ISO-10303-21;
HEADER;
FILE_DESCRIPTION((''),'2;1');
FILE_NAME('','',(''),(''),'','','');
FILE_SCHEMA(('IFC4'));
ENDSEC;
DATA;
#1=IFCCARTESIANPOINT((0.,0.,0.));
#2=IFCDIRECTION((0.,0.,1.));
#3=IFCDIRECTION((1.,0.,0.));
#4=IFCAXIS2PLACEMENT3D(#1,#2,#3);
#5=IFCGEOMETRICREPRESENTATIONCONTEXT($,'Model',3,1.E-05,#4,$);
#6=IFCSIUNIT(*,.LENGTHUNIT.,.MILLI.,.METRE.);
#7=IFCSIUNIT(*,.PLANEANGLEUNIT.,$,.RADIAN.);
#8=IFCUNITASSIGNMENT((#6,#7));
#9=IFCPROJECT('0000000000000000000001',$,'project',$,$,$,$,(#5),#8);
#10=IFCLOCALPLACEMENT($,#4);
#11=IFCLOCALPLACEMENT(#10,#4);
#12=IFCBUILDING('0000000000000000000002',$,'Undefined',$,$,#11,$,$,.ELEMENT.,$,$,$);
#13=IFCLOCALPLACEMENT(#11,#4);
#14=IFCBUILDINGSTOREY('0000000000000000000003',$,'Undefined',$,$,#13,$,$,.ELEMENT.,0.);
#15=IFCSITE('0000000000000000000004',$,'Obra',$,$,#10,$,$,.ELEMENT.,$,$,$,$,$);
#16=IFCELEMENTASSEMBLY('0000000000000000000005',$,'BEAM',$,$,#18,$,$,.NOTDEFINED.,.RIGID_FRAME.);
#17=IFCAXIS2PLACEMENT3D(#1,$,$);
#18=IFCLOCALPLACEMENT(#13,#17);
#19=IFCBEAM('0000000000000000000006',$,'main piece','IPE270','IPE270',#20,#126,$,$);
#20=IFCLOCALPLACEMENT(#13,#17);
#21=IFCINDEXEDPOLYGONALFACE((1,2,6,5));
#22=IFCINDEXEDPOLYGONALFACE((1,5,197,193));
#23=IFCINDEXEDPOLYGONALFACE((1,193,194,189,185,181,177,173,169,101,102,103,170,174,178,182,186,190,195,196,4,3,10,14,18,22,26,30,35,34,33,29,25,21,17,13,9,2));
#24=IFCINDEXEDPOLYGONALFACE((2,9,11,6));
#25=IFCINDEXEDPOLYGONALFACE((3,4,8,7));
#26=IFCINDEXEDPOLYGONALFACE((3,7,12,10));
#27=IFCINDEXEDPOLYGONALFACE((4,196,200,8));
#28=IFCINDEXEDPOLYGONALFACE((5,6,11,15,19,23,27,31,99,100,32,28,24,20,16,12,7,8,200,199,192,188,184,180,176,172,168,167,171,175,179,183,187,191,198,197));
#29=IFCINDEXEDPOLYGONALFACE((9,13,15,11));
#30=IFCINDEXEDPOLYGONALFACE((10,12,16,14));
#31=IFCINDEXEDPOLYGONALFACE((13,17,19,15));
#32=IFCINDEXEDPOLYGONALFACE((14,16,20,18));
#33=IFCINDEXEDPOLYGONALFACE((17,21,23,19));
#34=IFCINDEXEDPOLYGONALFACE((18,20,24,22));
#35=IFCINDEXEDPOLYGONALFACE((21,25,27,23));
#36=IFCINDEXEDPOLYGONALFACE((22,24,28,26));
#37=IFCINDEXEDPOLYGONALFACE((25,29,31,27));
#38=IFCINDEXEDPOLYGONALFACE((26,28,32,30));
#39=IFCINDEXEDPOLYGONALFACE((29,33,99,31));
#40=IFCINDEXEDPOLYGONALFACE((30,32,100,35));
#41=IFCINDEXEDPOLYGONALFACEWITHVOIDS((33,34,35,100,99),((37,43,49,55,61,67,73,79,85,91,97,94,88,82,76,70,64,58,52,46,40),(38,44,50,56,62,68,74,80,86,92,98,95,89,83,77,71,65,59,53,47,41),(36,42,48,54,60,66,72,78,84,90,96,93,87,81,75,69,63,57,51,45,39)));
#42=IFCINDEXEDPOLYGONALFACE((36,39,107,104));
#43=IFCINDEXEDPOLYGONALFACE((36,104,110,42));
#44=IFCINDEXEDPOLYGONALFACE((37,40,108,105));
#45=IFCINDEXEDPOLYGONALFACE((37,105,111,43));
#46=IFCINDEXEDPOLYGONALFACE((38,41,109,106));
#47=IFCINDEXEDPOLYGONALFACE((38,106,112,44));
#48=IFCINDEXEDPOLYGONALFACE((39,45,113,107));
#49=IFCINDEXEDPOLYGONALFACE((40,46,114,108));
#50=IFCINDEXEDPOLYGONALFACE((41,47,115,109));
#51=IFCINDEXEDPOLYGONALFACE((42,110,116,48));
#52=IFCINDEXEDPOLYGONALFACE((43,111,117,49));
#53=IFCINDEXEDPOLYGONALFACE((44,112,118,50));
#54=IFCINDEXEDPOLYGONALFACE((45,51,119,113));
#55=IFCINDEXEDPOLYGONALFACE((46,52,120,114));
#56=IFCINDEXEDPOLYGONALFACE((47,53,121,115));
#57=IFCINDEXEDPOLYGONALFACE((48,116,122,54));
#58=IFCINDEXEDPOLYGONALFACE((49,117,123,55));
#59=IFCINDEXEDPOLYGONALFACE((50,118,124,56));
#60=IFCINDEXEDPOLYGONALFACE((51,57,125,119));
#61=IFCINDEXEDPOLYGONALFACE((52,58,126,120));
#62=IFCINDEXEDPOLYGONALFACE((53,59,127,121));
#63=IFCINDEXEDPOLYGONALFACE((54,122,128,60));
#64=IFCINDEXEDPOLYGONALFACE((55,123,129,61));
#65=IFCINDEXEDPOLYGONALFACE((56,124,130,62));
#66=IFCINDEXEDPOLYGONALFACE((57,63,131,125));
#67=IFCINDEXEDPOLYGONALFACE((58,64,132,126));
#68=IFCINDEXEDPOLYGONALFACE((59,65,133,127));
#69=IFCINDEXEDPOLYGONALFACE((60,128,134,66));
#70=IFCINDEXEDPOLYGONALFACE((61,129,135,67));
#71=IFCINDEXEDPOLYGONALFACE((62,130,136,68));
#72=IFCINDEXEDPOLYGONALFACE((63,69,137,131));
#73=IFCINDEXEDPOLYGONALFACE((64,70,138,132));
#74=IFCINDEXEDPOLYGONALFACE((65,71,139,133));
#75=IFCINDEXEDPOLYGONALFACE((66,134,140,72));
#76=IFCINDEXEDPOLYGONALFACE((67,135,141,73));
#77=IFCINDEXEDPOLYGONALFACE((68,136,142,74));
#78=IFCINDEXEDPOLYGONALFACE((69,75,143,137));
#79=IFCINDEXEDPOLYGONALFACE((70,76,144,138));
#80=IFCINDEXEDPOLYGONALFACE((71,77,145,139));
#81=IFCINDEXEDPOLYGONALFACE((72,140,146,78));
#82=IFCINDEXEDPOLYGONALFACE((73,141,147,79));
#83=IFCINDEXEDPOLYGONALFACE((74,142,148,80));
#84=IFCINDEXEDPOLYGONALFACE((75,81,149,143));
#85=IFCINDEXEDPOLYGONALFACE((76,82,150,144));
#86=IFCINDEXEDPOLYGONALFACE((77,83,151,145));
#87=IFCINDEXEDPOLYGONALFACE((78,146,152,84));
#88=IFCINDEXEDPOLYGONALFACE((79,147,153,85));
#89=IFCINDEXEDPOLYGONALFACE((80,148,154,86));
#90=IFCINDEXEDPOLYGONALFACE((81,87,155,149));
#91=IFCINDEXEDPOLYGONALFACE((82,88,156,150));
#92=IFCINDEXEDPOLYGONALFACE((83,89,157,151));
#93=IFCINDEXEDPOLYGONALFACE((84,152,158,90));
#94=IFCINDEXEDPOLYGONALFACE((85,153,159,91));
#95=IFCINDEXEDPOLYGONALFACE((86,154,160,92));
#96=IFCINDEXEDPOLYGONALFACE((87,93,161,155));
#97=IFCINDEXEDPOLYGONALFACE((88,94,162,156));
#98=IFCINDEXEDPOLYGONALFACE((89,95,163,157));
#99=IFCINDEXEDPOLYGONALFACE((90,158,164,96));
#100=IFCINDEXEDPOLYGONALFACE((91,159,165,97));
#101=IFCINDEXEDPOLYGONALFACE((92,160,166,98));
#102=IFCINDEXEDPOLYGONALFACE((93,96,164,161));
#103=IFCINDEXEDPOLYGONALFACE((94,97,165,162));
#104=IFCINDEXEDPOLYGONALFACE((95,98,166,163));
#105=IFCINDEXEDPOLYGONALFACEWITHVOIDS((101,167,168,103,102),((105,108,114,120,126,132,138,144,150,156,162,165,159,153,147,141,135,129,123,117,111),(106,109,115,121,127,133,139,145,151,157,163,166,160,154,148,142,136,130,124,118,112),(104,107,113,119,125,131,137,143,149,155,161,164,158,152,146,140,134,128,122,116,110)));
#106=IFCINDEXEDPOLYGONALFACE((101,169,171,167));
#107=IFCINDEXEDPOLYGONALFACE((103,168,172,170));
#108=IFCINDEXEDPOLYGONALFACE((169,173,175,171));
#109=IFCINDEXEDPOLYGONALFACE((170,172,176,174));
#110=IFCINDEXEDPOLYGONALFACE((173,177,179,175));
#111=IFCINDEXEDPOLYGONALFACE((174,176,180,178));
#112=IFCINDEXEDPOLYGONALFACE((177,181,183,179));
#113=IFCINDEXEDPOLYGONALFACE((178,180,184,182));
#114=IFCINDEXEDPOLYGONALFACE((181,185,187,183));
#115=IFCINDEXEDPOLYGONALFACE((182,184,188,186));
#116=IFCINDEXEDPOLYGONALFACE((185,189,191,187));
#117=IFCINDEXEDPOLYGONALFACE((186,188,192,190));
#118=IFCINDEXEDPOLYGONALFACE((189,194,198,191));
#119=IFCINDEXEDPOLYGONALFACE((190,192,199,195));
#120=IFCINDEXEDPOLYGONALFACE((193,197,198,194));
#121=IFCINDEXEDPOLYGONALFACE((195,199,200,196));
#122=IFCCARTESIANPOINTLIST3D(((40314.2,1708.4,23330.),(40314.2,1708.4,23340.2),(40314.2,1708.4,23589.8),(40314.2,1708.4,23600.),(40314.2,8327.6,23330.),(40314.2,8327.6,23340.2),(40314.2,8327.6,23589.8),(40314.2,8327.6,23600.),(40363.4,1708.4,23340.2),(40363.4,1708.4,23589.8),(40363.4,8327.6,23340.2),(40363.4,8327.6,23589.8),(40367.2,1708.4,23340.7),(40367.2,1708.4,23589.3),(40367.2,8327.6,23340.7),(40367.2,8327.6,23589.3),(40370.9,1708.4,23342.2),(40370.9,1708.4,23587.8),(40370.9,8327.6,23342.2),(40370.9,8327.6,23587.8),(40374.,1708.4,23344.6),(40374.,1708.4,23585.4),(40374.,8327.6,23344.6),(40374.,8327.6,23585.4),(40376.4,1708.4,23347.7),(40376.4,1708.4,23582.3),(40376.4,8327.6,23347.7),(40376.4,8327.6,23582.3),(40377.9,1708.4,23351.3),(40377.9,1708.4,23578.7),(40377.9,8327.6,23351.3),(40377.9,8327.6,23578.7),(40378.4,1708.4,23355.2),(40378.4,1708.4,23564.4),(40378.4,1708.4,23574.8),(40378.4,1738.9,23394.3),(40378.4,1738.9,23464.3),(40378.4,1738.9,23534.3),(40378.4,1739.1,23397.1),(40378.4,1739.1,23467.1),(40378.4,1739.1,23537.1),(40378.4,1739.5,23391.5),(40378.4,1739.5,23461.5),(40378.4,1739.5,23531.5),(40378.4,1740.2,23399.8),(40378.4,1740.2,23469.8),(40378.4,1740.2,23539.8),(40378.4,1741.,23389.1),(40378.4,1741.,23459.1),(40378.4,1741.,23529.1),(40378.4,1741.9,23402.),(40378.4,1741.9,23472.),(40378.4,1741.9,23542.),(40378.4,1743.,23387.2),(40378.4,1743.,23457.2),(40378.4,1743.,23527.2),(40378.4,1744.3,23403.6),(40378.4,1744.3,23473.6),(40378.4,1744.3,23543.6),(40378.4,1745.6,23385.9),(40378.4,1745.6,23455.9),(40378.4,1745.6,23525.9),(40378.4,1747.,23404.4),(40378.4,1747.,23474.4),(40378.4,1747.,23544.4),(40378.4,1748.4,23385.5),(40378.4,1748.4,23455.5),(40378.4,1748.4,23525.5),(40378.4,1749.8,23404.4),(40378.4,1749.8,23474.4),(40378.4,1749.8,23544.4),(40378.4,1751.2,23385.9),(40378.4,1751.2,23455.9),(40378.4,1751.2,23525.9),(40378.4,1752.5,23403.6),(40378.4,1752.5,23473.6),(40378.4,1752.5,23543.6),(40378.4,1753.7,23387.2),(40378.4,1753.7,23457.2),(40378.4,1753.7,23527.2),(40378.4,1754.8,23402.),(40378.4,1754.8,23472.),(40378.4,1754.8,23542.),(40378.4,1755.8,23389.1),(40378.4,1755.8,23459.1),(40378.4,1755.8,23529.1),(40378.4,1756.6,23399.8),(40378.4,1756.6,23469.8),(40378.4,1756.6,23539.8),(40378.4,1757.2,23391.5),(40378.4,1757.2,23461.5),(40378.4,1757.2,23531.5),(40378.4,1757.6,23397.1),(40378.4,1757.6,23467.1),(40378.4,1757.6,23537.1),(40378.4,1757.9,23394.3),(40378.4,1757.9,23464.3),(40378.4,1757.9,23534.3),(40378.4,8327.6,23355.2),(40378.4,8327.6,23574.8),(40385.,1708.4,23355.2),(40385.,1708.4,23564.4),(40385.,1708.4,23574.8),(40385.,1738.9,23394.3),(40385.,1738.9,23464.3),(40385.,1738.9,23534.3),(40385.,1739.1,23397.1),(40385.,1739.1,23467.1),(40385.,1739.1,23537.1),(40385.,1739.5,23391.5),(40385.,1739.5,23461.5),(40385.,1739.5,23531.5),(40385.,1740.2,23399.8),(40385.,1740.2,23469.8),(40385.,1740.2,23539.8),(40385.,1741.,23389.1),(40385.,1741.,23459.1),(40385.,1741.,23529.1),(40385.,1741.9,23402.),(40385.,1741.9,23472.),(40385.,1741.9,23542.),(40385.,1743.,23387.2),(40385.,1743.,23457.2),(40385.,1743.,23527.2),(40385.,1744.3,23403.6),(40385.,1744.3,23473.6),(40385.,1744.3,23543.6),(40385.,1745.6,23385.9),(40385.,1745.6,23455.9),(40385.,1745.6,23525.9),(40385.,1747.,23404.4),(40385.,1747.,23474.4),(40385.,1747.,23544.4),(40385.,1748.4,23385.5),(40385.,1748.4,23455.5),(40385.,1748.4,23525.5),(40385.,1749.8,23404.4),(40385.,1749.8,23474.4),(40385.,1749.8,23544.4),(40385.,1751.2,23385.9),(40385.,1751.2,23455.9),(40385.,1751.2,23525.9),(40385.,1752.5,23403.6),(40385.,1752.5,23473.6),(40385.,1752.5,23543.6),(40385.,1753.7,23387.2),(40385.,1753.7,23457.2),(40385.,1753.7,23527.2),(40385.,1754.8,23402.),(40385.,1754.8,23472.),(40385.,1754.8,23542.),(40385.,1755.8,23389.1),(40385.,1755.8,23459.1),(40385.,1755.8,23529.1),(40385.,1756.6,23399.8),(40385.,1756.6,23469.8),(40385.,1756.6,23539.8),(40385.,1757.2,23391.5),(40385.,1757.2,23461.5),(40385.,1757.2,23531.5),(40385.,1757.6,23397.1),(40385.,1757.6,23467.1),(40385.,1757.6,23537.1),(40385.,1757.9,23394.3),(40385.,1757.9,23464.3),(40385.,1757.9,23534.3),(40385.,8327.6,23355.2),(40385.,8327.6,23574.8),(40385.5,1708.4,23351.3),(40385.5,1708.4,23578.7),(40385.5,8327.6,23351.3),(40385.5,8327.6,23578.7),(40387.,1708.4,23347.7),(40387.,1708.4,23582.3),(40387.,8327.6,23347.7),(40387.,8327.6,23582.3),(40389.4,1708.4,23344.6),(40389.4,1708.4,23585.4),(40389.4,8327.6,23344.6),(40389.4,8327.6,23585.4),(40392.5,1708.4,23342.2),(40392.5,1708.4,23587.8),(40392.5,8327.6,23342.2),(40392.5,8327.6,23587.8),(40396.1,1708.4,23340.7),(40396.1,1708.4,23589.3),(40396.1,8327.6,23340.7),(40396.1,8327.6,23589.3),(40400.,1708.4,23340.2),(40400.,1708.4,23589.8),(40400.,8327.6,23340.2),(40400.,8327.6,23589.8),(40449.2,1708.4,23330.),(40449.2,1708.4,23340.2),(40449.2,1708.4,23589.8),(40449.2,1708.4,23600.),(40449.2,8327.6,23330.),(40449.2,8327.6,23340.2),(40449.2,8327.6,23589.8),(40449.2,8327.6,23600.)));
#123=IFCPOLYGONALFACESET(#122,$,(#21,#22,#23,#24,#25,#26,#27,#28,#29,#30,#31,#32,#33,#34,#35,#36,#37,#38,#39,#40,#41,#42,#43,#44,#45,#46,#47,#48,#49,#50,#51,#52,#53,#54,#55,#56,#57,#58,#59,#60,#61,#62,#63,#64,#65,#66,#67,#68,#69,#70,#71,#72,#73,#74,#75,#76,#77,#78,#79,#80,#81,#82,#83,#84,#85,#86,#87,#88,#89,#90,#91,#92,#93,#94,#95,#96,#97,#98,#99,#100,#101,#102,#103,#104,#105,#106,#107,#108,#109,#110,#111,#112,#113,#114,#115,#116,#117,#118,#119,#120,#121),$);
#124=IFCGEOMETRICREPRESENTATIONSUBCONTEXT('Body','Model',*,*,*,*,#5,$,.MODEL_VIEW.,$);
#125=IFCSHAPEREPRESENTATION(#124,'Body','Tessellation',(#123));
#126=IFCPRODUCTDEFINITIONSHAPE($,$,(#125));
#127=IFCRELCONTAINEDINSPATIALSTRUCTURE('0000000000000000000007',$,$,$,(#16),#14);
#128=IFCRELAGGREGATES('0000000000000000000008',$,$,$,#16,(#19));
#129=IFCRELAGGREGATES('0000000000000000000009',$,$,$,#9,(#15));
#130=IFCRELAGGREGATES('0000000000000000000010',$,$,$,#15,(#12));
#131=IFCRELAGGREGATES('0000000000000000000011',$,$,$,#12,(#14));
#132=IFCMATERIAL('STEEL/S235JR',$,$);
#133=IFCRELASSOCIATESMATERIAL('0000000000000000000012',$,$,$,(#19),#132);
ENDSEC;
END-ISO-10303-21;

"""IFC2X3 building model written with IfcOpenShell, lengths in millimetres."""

from ifc_helpers import new_model, si_unit, frame, origin_with_axes, origin_2d_with_axis, place, context, subcontext, project, spatial, rectangle, circle, i_section, extrude, clip, halfspace, source, transform, mapped, material, element, aggregate, save


model = new_model("IFC2X3")

# Units and contexts
model_context = context("Model", 3, precision=1e-05, world=origin_with_axes())
body_context = subcontext(model_context, "Body", "Model", "MODEL_VIEW")
ifc_project = project(units=[si_unit("LENGTHUNIT", "METRE", prefix="MILLI"), si_unit("PLANEANGLEUNIT", "RADIAN")], contexts=[model_context])

# Site, building, storey
site_placement = place(None, origin_with_axes())
site = spatial("IfcSite", under=ifc_project, at=site_placement, Name="Obra", CompositionType="ELEMENT")
building_placement = place(site_placement, origin_with_axes())
building = spatial("IfcBuilding", under=site, at=building_placement, Name="Undefined", CompositionType="ELEMENT")
storey_placement = place(building_placement, origin_with_axes())
storey = spatial("IfcBuildingStorey", under=building, at=storey_placement, Name="Undefined", CompositionType="ELEMENT", Elevation=0.0)

# Shared definitions
ifc_material_1 = material(Name="STEEL/S235JR")

# Element assembly, beam, openings
assembly_1_placement = place(storey_placement, origin_with_axes())
assembly_1 = element("IfcElementAssembly", 1, at=assembly_1_placement, inside=storey, Name="BEAM", AssemblyPlace="NOTDEFINED", PredefinedType="RIGID_FRAME")
beam_1_placement = place(assembly_1_placement, frame((40381.7, 1711.1, 23465.0), z_axis=(0.0, 0.0, 1.0), x_axis=(0.0, 1.0, 0.0)))
beam_1 = element("IfcBeam", 2, at=beam_1_placement, material=ifc_material_1, Name="main piece", Description="IPE270", ObjectType="IPE270", context=body_context, shape_type="Clipping", body=[
    clip(clip(extrude(i_section(OverallWidth=135.0, OverallDepth=270.0, WebThickness=6.6, FlangeThickness=10.2, FilletRadius=15.0, at=origin_2d_with_axis()), frame((6656.0, 0.0, 0.0), z_axis=(-1.0, 0.0, 0.0), x_axis=(0.0, -1.0, 0.0)), (0.0, 0.0, 1.0), 6658.7), halfspace(frame((6616.5, -60.0, -120.0), z_axis=(1.0, 0.0, 0.0), x_axis=(0.0, 0.0, 1.0)), False)), halfspace(frame((-2.7, 0.0, -235.0), z_axis=(1.0, 0.0, 0.0), x_axis=(0.0, -1.0, 0.0)), True)),
])
opening_1_placement = place(assembly_1_placement, frame((40381.7, 1711.1, 23465.0), z_axis=(0.0, 0.0, 1.0), x_axis=(0.0, 1.0, 0.0)))
element("IfcOpeningElement", 3, at=opening_1_placement, cuts=beam_1, ObjectType="Recess", context=body_context, shape_type="SweptSolid", body=[
    extrude(rectangle(XDim=36.6, YDim=102.3, at=origin_2d_with_axis()), frame((-53.9, -68.5, 117.7), z_axis=(0.0, 1.0, 0.0), x_axis=(0.0, 0.0, -1.0)), (0.0, 0.0, 1.0), 137.0),
])
shared_shape_1 = source(origin_with_axes(), body_context, "Body", "SweptSolid", [
    extrude(circle(Radius=9.5, at=origin_2d_with_axis()), frame((0.0, -3.4, 0.0), z_axis=(0.0, 1.0, 0.0), x_axis=(1.0, 0.0, 0.0)), (0.0, 0.0, 1.0), 6.8),
])
opening_2_placement = place(assembly_1_placement, frame((40381.7, 1708.4, 23570.0), z_axis=(0.0, 1.0, 0.0), x_axis=(0.0, 0.0, -1.0)))
element("IfcOpeningElement", 4, at=opening_2_placement, cuts=beam_1, ObjectType="Opening", context=body_context, shape_type="MappedRepresentation", body=[
    mapped(shared_shape_1, transform((35.0, 0.0, 40.0))),
    mapped(shared_shape_1, transform((105.0, 0.0, 40.0))),
    mapped(shared_shape_1, transform((175.0, 0.0, 40.0))),
])

aggregate(assembly_1, [beam_1])

save(model, "model.ifc")
